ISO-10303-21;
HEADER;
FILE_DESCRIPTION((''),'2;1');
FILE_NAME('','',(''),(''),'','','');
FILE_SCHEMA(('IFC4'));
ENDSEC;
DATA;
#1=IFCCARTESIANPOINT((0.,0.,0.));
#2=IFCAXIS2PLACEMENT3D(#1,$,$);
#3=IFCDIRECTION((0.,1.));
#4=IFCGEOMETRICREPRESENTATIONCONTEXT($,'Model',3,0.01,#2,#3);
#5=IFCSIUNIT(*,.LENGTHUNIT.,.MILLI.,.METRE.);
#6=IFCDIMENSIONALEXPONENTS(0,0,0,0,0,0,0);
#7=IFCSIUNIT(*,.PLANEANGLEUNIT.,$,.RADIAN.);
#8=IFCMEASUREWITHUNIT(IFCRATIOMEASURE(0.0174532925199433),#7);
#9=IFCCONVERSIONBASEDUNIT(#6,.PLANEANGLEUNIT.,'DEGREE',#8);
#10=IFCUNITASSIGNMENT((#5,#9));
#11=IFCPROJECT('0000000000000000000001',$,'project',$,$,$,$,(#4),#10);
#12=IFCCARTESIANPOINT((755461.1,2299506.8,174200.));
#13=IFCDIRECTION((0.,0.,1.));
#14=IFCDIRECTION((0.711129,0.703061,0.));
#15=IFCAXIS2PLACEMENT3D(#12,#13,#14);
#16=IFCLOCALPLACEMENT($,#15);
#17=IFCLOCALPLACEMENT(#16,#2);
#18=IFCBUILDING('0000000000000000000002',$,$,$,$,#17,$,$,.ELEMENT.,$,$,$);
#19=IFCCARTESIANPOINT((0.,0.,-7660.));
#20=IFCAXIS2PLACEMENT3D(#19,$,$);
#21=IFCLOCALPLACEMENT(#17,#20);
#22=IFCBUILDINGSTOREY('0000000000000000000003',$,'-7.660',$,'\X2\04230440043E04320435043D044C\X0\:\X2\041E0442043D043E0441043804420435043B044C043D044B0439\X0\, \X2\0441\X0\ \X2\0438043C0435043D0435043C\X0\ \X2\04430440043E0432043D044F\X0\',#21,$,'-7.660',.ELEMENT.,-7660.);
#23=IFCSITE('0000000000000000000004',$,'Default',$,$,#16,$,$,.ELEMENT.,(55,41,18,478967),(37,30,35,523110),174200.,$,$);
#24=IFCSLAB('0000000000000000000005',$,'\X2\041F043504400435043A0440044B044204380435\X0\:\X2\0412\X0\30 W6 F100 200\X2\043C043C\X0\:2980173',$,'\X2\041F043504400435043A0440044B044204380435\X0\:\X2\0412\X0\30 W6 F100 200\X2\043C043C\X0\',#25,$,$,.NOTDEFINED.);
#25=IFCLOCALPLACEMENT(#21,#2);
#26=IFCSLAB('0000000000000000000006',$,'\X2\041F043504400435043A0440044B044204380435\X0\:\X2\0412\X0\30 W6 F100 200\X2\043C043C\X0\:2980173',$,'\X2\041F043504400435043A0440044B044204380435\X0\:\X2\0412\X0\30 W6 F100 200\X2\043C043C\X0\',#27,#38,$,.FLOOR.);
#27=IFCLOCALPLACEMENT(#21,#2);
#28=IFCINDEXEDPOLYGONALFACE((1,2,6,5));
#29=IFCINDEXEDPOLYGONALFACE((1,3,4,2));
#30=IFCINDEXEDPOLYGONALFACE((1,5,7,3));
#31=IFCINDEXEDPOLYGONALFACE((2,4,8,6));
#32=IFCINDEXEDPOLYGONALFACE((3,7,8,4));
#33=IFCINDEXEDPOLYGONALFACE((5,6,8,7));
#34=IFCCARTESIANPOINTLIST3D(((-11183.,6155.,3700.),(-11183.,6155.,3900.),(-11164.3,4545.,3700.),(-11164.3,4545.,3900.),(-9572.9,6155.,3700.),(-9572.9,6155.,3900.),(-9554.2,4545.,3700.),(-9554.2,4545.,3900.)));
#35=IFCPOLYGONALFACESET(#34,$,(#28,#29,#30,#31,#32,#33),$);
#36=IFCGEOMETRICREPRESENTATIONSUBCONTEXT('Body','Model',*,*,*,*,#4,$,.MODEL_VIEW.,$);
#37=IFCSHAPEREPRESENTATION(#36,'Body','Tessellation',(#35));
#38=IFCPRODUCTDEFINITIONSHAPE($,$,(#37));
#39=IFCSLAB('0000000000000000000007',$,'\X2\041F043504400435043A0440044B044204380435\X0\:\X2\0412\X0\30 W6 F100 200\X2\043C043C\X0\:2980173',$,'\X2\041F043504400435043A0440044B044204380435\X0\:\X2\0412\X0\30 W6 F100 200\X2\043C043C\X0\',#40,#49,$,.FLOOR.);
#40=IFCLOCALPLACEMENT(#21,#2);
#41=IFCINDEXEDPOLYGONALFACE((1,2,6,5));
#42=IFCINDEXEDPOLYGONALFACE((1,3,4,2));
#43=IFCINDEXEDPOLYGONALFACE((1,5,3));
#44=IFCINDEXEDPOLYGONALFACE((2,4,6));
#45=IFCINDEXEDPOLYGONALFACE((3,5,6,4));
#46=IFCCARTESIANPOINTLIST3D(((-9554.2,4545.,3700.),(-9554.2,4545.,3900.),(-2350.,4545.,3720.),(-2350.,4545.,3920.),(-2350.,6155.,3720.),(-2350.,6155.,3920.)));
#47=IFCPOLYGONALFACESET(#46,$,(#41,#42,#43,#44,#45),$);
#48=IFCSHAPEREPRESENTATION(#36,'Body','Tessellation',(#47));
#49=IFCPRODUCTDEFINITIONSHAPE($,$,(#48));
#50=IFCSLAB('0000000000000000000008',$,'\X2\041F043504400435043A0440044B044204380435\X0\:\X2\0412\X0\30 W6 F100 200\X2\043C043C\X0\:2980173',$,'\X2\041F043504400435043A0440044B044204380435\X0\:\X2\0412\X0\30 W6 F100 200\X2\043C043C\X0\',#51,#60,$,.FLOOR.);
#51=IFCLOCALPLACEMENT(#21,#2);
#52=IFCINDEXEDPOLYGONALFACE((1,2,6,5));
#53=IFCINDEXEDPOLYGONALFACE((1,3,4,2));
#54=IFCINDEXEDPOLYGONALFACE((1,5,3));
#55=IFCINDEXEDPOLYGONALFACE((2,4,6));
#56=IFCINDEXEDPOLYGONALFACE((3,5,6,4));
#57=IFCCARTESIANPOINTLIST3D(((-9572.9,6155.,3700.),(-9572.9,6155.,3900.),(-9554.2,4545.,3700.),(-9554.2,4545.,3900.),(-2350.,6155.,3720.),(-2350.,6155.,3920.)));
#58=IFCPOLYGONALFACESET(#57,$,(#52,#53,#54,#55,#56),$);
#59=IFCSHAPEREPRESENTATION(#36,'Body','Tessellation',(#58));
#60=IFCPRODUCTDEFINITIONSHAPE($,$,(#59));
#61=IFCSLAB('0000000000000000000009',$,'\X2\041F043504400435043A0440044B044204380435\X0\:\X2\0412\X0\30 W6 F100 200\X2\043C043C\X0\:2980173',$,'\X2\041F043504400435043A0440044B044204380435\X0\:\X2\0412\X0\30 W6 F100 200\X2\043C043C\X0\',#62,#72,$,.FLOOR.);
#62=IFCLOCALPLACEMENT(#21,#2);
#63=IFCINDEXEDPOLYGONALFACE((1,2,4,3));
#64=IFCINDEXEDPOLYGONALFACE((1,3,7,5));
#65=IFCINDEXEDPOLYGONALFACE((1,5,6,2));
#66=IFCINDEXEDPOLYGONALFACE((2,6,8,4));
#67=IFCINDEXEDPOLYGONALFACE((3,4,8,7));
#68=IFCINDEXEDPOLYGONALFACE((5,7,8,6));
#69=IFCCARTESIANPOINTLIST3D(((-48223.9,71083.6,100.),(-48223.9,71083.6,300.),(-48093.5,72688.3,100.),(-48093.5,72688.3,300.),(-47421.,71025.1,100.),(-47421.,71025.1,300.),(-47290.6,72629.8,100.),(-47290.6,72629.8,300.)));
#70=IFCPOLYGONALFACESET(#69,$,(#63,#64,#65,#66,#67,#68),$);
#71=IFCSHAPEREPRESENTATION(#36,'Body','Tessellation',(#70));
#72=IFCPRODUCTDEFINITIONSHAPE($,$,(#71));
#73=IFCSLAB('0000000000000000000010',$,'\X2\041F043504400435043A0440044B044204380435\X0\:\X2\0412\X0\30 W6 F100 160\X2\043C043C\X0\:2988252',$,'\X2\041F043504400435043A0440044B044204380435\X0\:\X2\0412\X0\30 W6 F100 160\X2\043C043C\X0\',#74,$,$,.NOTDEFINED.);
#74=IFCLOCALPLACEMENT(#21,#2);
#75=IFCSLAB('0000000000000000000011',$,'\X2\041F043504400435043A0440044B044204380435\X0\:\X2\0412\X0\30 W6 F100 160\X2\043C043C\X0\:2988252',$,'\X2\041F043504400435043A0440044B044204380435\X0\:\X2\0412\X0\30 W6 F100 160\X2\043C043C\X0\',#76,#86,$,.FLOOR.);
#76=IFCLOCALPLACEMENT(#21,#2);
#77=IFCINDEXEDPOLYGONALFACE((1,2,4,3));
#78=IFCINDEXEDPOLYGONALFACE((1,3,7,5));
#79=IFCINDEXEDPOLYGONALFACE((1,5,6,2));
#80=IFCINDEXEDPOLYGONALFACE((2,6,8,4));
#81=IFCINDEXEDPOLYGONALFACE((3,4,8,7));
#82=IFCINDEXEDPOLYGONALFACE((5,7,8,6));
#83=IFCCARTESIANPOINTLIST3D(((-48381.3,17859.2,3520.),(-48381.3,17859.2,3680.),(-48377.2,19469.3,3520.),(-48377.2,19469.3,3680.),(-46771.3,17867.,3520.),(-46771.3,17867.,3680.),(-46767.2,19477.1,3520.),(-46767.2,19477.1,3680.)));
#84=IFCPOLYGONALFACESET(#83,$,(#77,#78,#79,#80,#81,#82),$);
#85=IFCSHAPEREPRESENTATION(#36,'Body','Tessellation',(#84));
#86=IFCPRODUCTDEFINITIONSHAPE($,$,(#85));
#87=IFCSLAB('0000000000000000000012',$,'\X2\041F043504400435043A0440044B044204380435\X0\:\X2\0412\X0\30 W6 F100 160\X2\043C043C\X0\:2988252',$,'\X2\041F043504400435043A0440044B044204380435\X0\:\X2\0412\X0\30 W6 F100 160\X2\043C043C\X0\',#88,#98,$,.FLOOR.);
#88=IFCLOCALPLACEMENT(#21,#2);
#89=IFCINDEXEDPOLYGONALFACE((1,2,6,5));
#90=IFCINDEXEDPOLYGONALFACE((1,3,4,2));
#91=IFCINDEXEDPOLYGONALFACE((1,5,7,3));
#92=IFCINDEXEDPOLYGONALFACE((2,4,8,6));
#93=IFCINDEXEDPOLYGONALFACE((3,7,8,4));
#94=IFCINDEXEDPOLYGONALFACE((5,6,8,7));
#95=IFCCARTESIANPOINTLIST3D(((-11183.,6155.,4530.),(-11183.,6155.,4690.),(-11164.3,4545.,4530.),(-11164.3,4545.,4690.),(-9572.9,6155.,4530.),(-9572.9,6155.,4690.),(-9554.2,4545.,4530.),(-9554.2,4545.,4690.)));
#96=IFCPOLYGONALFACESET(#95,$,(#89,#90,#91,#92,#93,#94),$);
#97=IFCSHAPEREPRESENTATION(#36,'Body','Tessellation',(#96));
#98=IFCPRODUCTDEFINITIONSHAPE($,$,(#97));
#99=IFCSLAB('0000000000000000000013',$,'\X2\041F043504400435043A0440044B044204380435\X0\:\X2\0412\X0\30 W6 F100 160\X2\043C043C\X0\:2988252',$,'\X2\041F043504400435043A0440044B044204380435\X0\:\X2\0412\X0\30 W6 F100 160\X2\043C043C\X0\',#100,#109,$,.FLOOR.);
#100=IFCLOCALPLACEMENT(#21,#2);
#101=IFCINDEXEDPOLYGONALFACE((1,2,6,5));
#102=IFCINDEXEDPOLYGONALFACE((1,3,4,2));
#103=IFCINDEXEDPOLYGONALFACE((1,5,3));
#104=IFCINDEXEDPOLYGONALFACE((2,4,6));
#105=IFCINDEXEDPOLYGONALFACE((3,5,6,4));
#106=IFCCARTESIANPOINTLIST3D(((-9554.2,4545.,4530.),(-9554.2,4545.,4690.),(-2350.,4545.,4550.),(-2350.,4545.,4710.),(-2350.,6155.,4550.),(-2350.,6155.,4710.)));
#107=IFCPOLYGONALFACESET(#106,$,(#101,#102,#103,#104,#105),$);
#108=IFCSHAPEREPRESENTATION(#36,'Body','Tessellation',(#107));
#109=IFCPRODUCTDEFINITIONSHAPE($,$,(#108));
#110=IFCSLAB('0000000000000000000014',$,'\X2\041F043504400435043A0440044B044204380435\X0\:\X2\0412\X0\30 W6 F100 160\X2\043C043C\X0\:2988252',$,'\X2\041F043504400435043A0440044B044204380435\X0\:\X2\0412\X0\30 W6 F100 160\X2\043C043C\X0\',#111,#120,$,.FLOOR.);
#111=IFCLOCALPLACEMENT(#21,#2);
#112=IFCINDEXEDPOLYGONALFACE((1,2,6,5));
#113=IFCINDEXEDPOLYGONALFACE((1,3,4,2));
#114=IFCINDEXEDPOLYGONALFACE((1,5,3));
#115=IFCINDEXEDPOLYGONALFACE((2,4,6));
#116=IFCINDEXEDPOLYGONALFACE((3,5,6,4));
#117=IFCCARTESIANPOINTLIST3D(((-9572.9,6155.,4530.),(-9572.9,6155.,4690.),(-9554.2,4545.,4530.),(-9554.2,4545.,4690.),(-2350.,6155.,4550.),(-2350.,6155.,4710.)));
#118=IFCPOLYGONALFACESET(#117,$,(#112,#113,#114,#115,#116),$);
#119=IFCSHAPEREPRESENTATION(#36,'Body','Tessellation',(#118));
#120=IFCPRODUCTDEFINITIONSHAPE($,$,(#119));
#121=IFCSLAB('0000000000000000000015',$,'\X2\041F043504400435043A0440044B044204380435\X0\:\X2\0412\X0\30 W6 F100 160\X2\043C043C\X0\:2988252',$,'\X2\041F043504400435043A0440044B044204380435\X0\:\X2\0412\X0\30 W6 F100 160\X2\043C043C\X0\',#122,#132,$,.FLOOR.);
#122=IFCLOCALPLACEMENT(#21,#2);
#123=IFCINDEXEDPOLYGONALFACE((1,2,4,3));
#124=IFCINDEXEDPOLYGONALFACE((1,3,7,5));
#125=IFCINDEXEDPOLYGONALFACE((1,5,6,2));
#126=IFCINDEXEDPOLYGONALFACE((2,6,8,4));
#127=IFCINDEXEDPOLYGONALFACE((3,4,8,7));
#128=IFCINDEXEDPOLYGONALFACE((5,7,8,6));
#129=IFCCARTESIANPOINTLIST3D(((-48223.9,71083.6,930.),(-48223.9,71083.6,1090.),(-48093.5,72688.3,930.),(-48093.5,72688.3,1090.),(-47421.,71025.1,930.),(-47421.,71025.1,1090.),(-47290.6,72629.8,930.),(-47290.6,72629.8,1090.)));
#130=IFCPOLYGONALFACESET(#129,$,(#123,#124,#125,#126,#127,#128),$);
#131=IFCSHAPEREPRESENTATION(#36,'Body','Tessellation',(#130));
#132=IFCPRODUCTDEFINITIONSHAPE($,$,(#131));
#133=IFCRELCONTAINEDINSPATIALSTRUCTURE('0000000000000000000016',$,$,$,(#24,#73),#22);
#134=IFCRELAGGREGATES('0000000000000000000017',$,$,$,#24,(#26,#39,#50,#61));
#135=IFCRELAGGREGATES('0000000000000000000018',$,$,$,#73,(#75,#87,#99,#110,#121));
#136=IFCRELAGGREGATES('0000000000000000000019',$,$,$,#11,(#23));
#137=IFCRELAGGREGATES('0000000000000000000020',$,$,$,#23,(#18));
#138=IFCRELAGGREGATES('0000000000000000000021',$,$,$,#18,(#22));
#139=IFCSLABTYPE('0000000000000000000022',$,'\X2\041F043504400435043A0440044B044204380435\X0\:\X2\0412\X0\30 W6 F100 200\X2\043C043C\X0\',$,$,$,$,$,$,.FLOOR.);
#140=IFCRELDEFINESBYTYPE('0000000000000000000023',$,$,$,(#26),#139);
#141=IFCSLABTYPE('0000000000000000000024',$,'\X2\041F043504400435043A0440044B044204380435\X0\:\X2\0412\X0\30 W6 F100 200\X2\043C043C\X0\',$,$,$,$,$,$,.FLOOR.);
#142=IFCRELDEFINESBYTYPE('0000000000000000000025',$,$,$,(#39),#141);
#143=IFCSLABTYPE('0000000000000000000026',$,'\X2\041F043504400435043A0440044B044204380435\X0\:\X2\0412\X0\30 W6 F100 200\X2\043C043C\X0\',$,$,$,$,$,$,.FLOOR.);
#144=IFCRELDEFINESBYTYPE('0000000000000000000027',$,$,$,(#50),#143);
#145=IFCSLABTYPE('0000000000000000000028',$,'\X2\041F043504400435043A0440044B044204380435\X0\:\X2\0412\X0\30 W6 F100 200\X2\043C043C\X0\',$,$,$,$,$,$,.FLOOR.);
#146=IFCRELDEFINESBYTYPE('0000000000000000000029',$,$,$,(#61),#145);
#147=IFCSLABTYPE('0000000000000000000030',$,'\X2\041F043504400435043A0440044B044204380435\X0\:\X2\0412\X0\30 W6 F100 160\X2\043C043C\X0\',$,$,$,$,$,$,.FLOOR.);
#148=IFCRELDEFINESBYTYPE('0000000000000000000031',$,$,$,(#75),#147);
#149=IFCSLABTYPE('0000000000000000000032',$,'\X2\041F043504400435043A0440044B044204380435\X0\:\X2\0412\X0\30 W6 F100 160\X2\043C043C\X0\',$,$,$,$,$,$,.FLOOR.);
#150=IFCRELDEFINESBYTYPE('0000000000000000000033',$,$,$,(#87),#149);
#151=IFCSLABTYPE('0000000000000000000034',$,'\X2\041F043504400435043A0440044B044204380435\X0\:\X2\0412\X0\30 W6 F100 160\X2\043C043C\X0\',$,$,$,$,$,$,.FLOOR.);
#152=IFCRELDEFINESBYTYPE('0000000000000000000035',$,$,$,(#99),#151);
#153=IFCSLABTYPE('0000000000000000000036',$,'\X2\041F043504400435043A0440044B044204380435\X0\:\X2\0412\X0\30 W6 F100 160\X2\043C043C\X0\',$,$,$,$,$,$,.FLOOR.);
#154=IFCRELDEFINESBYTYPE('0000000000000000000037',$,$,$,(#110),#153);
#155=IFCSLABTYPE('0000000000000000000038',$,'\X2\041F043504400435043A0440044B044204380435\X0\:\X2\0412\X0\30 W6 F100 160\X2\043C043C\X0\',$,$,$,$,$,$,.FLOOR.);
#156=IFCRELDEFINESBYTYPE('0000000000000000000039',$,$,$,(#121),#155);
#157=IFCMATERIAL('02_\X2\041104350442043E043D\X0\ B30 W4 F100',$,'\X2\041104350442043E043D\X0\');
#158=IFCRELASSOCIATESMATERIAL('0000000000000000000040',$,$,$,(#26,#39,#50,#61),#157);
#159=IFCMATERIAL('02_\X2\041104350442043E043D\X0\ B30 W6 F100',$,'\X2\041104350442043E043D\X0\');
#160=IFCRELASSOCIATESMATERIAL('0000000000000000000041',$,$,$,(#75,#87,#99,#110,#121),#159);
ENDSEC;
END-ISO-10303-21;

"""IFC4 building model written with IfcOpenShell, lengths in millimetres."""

from ifc_helpers import new_model, entity, si_unit, converted_unit, direction, frame, origin, place, context, subcontext, project, spatial, indexed_curve, outline, extrude, material, type_object, element, aggregate, save


model = new_model("IFC4")

# Units and contexts
model_context = context("Model", 3, precision=0.01, world=origin(), true_north=direction((0.0, 1.0)))
body_context = subcontext(model_context, "Body", "Model", "MODEL_VIEW")
ifc_project = project(units=[si_unit("LENGTHUNIT", "METRE", prefix="MILLI"), converted_unit("PLANEANGLEUNIT", "DEGREE", entity("IfcRatioMeasure", 0.0174532925199433), si_unit("PLANEANGLEUNIT", "RADIAN"), dimensions=[0, 0, 0, 0, 0, 0, 0])], contexts=[model_context])

# Site, building, storey
site_placement = place(None, frame((755461.1, 2299506.8, 174200.0), z_axis=(0.0, 0.0, 1.0), x_axis=(0.711129, 0.703061, 0.0)))
site = spatial("IfcSite", under=ifc_project, at=site_placement, Name="Default", CompositionType="ELEMENT", RefLatitude=(55, 41, 18, 478967), RefLongitude=(37, 30, 35, 523110), RefElevation=174200.0)
building_placement = place(site_placement, origin())
building = spatial("IfcBuilding", under=site, at=building_placement, CompositionType="ELEMENT")
storey_placement = place(building_placement, frame((0.0, 0.0, -7660.0)))
storey = spatial("IfcBuildingStorey", under=building, at=storey_placement, Name="-7.660", ObjectType="Уровень:Относительный, с именем уровня", LongName="-7.660", CompositionType="ELEMENT", Elevation=-7660.0)

# Slabs
slab_1_placement = place(storey_placement, frame((-48381.3, 4545.0, 100.0)))
slab_1 = element("IfcSlab", 1, at=slab_1_placement, inside=storey, Name="Перекрытие:В30 W6 F100 200мм:2980173", ObjectType="Перекрытие:В30 W6 F100 200мм", PredefinedType="NOTDEFINED")
ifc_material_1 = material(Name="02_Бетон B30 W4 F100", Category="Бетон")
slab_type_1 = type_object("IfcSlabType", Name="Перекрытие:В30 W6 F100 200мм", PredefinedType="FLOOR")
slab_2_placement = place(slab_1_placement, origin())
slab_2 = element("IfcSlab", 2, at=slab_2_placement, type_object=slab_type_1, material=ifc_material_1, Name="Перекрытие:В30 W6 F100 200мм:2980173", ObjectType="Перекрытие:В30 W6 F100 200мм", PredefinedType="FLOOR", context=body_context, shape_type="SweptSolid", body=[
    extrude(outline(indexed_curve([(-795.7, -805.0), (814.4, -805.0), (795.7, 805.0), (-814.4, 805.0), (-795.7, -805.0)], self_intersect=False)), frame((38012.7, 805.0, 3800.0)), (0.0, 0.0, -1.0), 200.0),
])
slab_type_2 = type_object("IfcSlabType", Name="Перекрытие:В30 W6 F100 200мм", PredefinedType="FLOOR")
slab_3_placement = place(slab_1_placement, origin())
slab_3 = element("IfcSlab", 3, at=slab_3_placement, type_object=slab_type_2, material=ifc_material_1, Name="Перекрытие:В30 W6 F100 200мм:2980173", ObjectType="Перекрытие:В30 W6 F100 200мм", PredefinedType="FLOOR", context=body_context, shape_type="SweptSolid", body=[
    extrude(outline(indexed_curve([(3602.1, -805.0), (3602.1, 805.0), (-3602.1, -805.0), (3602.1, -805.0)], self_intersect=False)), frame((42429.2, 805.0, 3810.0), z_axis=(-0.002776, 0.0, 0.999996), x_axis=(0.999996, 0.0, 0.002776)), (-0.002776, 0.0, -0.999996), 200.0),
])
slab_type_3 = type_object("IfcSlabType", Name="Перекрытие:В30 W6 F100 200мм", PredefinedType="FLOOR")
slab_4_placement = place(slab_1_placement, origin())
slab_4 = element("IfcSlab", 4, at=slab_4_placement, type_object=slab_type_3, material=ifc_material_1, Name="Перекрытие:В30 W6 F100 200мм:2980173", ObjectType="Перекрытие:В30 W6 F100 200мм", PredefinedType="FLOOR", context=body_context, shape_type="SweptSolid", body=[
    extrude(outline(indexed_curve([(3611.5, 805.0), (-3611.5, 805.0), (-3592.8, -805.0), (3611.5, 805.0)], self_intersect=False)), frame((42419.9, 805.0, 3810.0), z_axis=(-0.002769, -0.000032, 0.999996), x_axis=(0.999996, 0.0, 0.002769)), (-0.002769, -0.000032, -0.999996), 200.0),
])
slab_type_4 = type_object("IfcSlabType", Name="Перекрытие:В30 W6 F100 200мм", PredefinedType="FLOOR")
slab_5_placement = place(slab_1_placement, origin())
slab_5 = element("IfcSlab", 5, at=slab_5_placement, type_object=slab_type_4, material=ifc_material_1, Name="Перекрытие:В30 W6 F100 200мм:2980173", ObjectType="Перекрытие:В30 W6 F100 200мм", PredefinedType="FLOOR", context=body_context, shape_type="SweptSolid", body=[
    extrude(outline(indexed_curve([(-336.2, 831.6), (-466.7, -773.1), (336.2, -831.6), (466.7, 773.1), (-336.2, 831.6)], self_intersect=False)), frame((624.1, 67311.7, 200.0)), (0.0, 0.0, -1.0), 200.0),
])
aggregate(slab_1, [slab_2, slab_3, slab_4, slab_5])
slab_6_placement = place(storey_placement, frame((-48381.3, 4545.0, 930.0)))
slab_6 = element("IfcSlab", 6, at=slab_6_placement, inside=storey, Name="Перекрытие:В30 W6 F100 160мм:2988252", ObjectType="Перекрытие:В30 W6 F100 160мм", PredefinedType="NOTDEFINED")
ifc_material_2 = material(Name="02_Бетон B30 W6 F100", Category="Бетон")
slab_type_5 = type_object("IfcSlabType", Name="Перекрытие:В30 W6 F100 160мм", PredefinedType="FLOOR")
slab_7_placement = place(slab_6_placement, origin())
slab_7 = element("IfcSlab", 7, at=slab_7_placement, type_object=slab_type_5, material=ifc_material_2, Name="Перекрытие:В30 W6 F100 160мм:2988252", ObjectType="Перекрытие:В30 W6 F100 160мм", PredefinedType="FLOOR", context=body_context, shape_type="SweptSolid", body=[
    extrude(outline(indexed_curve([(-807.1, -808.9), (802.9, -801.1), (807.1, 808.9), (-802.9, 801.1), (-807.1, -808.9)], self_intersect=False)), frame((807.1, 14123.1, 2750.0)), (0.0, 0.0, -1.0), 160.0),
])
slab_type_6 = type_object("IfcSlabType", Name="Перекрытие:В30 W6 F100 160мм", PredefinedType="FLOOR")
slab_8_placement = place(slab_6_placement, origin())
slab_8 = element("IfcSlab", 8, at=slab_8_placement, type_object=slab_type_6, material=ifc_material_2, Name="Перекрытие:В30 W6 F100 160мм:2988252", ObjectType="Перекрытие:В30 W6 F100 160мм", PredefinedType="FLOOR", context=body_context, shape_type="SweptSolid", body=[
    extrude(outline(indexed_curve([(-795.7, -805.0), (814.4, -805.0), (795.7, 805.0), (-814.4, 805.0), (-795.7, -805.0)], self_intersect=False)), frame((38012.7, 805.0, 3760.0)), (0.0, 0.0, -1.0), 160.0),
])
slab_type_7 = type_object("IfcSlabType", Name="Перекрытие:В30 W6 F100 160мм", PredefinedType="FLOOR")
slab_9_placement = place(slab_6_placement, origin())
slab_9 = element("IfcSlab", 9, at=slab_9_placement, type_object=slab_type_7, material=ifc_material_2, Name="Перекрытие:В30 W6 F100 160мм:2988252", ObjectType="Перекрытие:В30 W6 F100 160мм", PredefinedType="FLOOR", context=body_context, shape_type="SweptSolid", body=[
    extrude(outline(indexed_curve([(3602.1, -805.0), (3602.1, 805.0), (-3602.1, -805.0), (3602.1, -805.0)], self_intersect=False)), frame((42429.2, 805.0, 3770.0), z_axis=(-0.002776, 0.0, 0.999996), x_axis=(0.999996, 0.0, 0.002776)), (-0.002776, 0.0, -0.999996), 160.0),
])
slab_type_8 = type_object("IfcSlabType", Name="Перекрытие:В30 W6 F100 160мм", PredefinedType="FLOOR")
slab_10_placement = place(slab_6_placement, origin())
slab_10 = element("IfcSlab", 10, at=slab_10_placement, type_object=slab_type_8, material=ifc_material_2, Name="Перекрытие:В30 W6 F100 160мм:2988252", ObjectType="Перекрытие:В30 W6 F100 160мм", PredefinedType="FLOOR", context=body_context, shape_type="SweptSolid", body=[
    extrude(outline(indexed_curve([(3611.5, 805.0), (-3611.5, 805.0), (-3592.8, -805.0), (3611.5, 805.0)], self_intersect=False)), frame((42419.9, 805.0, 3770.0), z_axis=(-0.002769, -0.000032, 0.999996), x_axis=(0.999996, 0.0, 0.002769)), (-0.002769, -0.000032, -0.999996), 160.0),
])
slab_type_9 = type_object("IfcSlabType", Name="Перекрытие:В30 W6 F100 160мм", PredefinedType="FLOOR")
slab_11_placement = place(slab_6_placement, origin())
slab_11 = element("IfcSlab", 11, at=slab_11_placement, type_object=slab_type_9, material=ifc_material_2, Name="Перекрытие:В30 W6 F100 160мм:2988252", ObjectType="Перекрытие:В30 W6 F100 160мм", PredefinedType="FLOOR", context=body_context, shape_type="SweptSolid", body=[
    extrude(outline(indexed_curve([(-336.2, 831.6), (-466.7, -773.1), (336.2, -831.6), (466.7, 773.1), (-336.2, 831.6)], self_intersect=False)), frame((624.1, 67311.7, 160.0)), (0.0, 0.0, -1.0), 160.0),
])
aggregate(slab_6, [slab_7, slab_8, slab_9, slab_10, slab_11])

save(model, "model.ifc")
